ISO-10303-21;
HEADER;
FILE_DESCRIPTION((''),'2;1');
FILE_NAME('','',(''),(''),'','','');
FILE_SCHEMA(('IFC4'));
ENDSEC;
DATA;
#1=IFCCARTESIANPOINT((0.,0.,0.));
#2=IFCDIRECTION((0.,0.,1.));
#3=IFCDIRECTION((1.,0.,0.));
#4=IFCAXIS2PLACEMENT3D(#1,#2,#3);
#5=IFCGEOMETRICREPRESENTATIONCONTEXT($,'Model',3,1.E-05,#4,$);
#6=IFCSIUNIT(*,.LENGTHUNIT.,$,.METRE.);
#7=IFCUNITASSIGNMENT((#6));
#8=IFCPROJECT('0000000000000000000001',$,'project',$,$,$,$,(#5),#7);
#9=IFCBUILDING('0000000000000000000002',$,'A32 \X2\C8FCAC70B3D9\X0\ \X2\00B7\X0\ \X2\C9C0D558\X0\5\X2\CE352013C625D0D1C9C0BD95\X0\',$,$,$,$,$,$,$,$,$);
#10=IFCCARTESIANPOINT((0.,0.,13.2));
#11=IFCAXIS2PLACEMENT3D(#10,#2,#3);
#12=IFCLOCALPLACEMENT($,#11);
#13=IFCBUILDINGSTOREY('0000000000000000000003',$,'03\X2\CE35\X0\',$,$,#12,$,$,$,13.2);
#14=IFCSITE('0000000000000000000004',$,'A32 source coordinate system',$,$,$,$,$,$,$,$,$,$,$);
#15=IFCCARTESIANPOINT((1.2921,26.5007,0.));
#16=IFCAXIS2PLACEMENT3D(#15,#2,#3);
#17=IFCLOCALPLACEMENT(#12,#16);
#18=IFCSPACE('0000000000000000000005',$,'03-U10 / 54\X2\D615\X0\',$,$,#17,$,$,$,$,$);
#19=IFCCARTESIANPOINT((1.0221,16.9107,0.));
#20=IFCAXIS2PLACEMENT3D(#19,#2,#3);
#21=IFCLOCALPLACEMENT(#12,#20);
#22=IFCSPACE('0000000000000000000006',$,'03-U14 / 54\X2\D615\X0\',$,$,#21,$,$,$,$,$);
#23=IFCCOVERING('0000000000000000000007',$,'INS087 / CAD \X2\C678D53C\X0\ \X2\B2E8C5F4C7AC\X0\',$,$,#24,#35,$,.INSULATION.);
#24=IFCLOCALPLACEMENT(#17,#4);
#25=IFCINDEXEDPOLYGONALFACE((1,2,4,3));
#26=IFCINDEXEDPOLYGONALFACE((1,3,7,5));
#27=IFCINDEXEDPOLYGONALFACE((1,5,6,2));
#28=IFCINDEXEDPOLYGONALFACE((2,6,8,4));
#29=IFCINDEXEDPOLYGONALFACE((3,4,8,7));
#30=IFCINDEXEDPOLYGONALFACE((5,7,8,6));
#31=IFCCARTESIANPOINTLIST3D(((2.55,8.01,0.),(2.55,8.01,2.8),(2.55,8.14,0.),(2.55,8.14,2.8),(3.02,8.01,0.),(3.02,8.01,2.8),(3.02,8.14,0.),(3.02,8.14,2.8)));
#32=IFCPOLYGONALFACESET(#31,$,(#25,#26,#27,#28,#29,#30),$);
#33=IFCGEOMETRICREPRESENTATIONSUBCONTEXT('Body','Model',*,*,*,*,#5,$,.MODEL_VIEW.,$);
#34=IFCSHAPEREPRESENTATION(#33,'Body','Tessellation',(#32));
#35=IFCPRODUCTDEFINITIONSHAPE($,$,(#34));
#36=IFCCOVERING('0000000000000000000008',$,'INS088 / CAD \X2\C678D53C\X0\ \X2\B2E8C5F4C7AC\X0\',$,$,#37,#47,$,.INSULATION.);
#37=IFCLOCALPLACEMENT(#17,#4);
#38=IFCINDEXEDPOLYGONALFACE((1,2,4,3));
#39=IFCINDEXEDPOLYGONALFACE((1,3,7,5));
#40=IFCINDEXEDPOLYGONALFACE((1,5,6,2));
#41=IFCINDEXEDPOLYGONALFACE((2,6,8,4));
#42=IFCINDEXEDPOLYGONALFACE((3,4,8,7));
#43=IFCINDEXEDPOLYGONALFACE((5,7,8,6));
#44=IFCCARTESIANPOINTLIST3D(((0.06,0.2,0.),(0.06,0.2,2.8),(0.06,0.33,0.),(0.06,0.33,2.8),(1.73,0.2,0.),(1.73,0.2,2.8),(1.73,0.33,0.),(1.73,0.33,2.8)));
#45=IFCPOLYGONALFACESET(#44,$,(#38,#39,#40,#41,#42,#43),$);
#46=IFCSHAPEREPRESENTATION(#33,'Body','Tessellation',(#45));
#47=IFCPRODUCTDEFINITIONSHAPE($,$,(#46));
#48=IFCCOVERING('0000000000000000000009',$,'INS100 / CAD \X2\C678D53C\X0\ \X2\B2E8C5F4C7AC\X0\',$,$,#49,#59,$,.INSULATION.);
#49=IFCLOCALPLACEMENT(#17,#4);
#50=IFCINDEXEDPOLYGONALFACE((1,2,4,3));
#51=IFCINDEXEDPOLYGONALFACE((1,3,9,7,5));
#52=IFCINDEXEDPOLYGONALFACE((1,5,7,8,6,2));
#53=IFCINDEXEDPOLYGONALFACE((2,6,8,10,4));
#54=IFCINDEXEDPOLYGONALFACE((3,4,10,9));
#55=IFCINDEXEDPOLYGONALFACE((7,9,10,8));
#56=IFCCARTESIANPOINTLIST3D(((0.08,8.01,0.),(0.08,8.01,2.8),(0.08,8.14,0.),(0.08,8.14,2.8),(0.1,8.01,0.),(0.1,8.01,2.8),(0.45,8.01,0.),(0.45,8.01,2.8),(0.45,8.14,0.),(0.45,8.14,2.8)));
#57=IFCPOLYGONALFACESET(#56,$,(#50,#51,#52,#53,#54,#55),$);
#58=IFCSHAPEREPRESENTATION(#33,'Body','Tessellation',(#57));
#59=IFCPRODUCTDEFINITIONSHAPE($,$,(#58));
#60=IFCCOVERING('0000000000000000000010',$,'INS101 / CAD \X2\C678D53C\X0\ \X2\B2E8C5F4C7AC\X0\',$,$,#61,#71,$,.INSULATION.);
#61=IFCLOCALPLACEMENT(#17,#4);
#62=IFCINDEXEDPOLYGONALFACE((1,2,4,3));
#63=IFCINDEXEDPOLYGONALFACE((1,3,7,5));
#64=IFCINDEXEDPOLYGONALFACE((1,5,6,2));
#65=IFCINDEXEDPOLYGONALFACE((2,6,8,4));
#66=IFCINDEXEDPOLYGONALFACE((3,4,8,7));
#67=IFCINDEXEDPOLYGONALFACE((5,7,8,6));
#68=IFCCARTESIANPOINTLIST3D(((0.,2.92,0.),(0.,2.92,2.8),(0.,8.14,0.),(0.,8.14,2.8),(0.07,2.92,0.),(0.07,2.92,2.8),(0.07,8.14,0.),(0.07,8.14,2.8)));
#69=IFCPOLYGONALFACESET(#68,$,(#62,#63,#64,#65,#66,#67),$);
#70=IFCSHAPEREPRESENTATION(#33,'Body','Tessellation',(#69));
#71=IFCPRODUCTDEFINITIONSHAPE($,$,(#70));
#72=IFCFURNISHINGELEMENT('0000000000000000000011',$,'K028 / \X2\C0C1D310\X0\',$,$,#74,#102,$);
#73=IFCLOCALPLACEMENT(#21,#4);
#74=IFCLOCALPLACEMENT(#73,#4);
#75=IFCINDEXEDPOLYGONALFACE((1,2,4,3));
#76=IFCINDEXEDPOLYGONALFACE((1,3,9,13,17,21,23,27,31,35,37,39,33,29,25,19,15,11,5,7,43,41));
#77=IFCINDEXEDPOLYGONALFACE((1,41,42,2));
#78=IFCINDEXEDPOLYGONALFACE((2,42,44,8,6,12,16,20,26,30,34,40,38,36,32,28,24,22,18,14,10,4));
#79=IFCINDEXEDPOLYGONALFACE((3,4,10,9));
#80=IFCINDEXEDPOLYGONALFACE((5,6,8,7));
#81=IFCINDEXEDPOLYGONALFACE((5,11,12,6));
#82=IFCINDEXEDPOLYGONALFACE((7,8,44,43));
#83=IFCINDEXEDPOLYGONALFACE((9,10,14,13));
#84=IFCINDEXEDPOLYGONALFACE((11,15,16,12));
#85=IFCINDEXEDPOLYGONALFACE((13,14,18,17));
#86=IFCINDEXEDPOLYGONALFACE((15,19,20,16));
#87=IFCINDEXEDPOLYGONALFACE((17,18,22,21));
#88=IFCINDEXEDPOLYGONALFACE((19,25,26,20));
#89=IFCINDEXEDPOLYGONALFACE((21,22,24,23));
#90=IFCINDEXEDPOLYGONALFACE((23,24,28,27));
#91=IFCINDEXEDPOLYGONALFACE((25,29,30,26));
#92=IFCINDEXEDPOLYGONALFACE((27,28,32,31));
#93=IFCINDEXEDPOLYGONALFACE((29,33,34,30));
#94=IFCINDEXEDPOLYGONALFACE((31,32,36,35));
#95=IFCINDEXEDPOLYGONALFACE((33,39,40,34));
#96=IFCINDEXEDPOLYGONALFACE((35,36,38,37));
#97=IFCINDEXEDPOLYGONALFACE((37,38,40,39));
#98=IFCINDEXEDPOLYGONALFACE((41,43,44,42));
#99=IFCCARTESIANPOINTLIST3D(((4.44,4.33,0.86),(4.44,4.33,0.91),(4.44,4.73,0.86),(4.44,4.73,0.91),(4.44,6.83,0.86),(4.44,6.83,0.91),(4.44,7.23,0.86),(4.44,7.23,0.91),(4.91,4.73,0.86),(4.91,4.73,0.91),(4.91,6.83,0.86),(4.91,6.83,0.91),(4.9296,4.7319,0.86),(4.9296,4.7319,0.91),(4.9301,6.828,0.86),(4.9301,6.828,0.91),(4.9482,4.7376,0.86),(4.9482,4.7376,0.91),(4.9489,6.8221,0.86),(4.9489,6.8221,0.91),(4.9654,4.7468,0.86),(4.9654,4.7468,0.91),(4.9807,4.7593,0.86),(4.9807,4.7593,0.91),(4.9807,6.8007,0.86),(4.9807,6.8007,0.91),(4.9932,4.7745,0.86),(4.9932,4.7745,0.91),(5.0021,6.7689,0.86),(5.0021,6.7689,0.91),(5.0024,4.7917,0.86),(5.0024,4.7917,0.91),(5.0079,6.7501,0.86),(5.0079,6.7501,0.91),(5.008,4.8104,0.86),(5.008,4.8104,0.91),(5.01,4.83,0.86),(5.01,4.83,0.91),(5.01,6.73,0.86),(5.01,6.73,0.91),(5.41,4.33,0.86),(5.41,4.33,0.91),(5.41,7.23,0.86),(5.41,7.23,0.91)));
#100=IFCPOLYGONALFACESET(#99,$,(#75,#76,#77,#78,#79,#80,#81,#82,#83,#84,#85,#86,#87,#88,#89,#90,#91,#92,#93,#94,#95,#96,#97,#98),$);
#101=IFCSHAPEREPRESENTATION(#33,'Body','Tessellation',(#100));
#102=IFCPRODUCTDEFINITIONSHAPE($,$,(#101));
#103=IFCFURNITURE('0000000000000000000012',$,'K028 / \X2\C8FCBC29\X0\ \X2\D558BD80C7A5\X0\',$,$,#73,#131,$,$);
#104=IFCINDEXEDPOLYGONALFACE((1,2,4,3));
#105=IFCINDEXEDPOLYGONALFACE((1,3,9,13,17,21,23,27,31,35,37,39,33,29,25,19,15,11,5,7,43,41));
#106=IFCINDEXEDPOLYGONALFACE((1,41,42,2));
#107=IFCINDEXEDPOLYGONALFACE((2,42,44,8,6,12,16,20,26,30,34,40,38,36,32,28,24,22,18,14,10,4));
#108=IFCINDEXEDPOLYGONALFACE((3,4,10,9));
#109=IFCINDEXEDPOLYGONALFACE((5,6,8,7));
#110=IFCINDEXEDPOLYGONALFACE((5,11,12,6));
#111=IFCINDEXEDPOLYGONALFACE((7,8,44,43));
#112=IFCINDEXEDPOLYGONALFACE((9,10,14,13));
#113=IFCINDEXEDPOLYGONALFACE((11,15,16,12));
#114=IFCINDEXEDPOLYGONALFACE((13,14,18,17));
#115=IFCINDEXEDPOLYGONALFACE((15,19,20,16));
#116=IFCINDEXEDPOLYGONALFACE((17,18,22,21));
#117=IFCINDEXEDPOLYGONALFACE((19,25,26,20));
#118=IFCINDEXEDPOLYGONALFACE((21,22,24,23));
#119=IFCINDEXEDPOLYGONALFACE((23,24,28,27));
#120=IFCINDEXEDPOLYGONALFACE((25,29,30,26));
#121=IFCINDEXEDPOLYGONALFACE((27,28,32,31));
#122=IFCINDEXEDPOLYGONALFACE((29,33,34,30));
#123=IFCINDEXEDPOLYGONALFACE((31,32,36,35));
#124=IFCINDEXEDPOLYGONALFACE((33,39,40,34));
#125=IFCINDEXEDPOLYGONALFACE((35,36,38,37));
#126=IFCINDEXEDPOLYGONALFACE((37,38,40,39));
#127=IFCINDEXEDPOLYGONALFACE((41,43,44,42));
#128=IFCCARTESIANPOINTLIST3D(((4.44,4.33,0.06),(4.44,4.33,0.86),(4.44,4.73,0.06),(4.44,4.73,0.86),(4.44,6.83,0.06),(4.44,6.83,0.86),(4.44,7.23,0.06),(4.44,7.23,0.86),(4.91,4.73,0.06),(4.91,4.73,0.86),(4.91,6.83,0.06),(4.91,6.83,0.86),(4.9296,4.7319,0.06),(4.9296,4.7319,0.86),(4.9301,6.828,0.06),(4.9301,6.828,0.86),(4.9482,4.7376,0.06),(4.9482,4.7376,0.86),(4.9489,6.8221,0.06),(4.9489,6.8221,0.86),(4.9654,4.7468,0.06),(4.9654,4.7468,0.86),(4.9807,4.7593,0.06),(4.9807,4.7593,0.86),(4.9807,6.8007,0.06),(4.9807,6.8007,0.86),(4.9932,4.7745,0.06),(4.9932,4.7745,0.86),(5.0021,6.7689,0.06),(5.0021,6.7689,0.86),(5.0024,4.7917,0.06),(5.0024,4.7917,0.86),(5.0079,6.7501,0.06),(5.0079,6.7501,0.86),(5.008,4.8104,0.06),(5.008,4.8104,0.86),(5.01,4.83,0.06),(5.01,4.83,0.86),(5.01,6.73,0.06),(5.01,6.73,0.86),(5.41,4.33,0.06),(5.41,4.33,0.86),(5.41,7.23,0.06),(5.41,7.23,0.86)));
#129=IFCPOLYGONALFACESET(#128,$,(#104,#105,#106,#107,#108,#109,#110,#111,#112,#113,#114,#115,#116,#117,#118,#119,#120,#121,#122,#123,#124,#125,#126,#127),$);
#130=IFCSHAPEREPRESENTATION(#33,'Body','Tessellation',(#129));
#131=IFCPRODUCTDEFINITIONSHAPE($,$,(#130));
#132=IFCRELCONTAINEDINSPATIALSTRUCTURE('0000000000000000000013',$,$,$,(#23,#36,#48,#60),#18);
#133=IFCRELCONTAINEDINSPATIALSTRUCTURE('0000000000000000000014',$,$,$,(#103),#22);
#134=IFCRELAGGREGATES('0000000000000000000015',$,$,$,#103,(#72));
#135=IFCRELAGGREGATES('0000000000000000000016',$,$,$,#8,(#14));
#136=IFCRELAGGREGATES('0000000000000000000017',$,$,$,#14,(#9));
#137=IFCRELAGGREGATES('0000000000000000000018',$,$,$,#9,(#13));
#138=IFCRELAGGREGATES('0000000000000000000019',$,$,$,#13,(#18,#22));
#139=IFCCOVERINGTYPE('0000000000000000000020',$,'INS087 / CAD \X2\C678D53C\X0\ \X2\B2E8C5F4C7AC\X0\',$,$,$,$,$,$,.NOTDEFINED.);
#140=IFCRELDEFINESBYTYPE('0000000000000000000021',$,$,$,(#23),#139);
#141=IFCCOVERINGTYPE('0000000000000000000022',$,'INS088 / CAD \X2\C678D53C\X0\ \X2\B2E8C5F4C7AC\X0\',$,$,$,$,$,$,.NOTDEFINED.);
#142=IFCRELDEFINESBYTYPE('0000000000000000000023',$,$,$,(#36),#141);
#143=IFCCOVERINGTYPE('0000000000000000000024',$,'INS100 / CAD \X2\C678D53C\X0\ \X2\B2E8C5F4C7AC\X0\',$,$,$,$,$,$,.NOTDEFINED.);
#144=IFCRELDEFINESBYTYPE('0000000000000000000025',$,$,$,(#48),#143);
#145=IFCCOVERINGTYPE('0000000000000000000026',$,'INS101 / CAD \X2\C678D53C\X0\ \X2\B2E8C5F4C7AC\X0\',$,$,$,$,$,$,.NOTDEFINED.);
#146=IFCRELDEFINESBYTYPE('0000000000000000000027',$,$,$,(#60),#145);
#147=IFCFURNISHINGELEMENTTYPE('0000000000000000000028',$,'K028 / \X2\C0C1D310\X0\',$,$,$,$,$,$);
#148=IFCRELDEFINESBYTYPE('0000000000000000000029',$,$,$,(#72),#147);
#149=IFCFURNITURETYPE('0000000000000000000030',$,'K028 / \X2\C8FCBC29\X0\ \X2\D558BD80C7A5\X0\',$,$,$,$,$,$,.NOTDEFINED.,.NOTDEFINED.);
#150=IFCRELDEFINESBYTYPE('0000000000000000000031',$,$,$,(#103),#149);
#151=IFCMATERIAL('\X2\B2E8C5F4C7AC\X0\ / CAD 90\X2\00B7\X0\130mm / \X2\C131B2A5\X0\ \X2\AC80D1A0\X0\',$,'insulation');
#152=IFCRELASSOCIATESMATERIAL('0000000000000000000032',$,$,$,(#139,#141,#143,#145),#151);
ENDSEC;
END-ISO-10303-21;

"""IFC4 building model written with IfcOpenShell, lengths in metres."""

from ifc_helpers import new_model, si_unit, frame, origin, origin_with_axes, place, context, subcontext, project, spatial, polyline, outline, extrude, source, transform, mapped, material, type_object, type_shapes, element, aggregate, save


model = new_model("IFC4")

# Units and contexts
model_context = context("Model", 3, precision=1e-05, world=origin_with_axes())
body_context = subcontext(model_context, "Body", "Model", "MODEL_VIEW")
ifc_project = project(units=[si_unit("LENGTHUNIT", "METRE")], contexts=[model_context])

# Site, building, storey, space
storey_placement = place(None, frame((0.0, 0.0, 13.2), z_axis=(0.0, 0.0, 1.0), x_axis=(1.0, 0.0, 0.0)))
space_1_placement = place(storey_placement, frame((1.2921, 26.5007, 0.0), z_axis=(0.0, 0.0, 1.0), x_axis=(1.0, 0.0, 0.0)))
site = spatial("IfcSite", under=ifc_project, Name="A32 source coordinate system")
building = spatial("IfcBuilding", under=site, Name="A32 주거동 · 지하5층–옥탑지붕")
storey = spatial("IfcBuildingStorey", under=building, at=storey_placement, Name="03층", Elevation=13.2)
space_1 = spatial("IfcSpace", under=storey, at=space_1_placement, Name="03-U10 / 54형")

# Shared definitions
space_2_placement = place(storey_placement, frame((1.0221, 16.9107, 0.0), z_axis=(0.0, 0.0, 1.0), x_axis=(1.0, 0.0, 0.0)))
space_2 = spatial("IfcSpace", under=storey, at=space_2_placement, Name="03-U14 / 54형")

# Coverings
ifc_material = material(Name="단열재 / CAD 90·130mm / 성능 검토", Category="insulation")
covering_type_1 = type_object("IfcCoveringType", Name="INS087 / CAD 외피 단열재", PredefinedType="NOTDEFINED", material=ifc_material)
shared_shape_1 = source(origin(), body_context, "Body", "SweptSolid", [
    extrude(outline(polyline([(2.55, 8.14), (3.02, 8.14), (3.02, 8.01), (2.55, 8.01), (2.55, 8.14)])), origin(), (0.0, 0.0, 1.0), 2.8),
])
type_shapes(covering_type_1, [shared_shape_1])
covering_1_placement = place(space_1_placement, origin_with_axes())
element("IfcCovering", 1, at=covering_1_placement, inside=space_1, type_object=covering_type_1, Name="INS087 / CAD 외피 단열재", PredefinedType="INSULATION", context=body_context, shape_type="MappedRepresentation", body=[
    mapped(shared_shape_1, transform((0.0, 0.0, 0.0), scale=1.0)),
])
covering_type_2 = type_object("IfcCoveringType", Name="INS088 / CAD 외피 단열재", PredefinedType="NOTDEFINED", material=ifc_material)
shared_shape_2 = source(origin(), body_context, "Body", "SweptSolid", [
    extrude(outline(polyline([(0.06, 0.33), (1.73, 0.33), (1.73, 0.2), (0.06, 0.2), (0.06, 0.33)])), origin(), (0.0, 0.0, 1.0), 2.8),
])
type_shapes(covering_type_2, [shared_shape_2])
covering_2_placement = place(space_1_placement, origin_with_axes())
element("IfcCovering", 2, at=covering_2_placement, inside=space_1, type_object=covering_type_2, Name="INS088 / CAD 외피 단열재", PredefinedType="INSULATION", context=body_context, shape_type="MappedRepresentation", body=[
    mapped(shared_shape_2, transform((0.0, 0.0, 0.0), scale=1.0)),
])
covering_type_3 = type_object("IfcCoveringType", Name="INS100 / CAD 외피 단열재", PredefinedType="NOTDEFINED", material=ifc_material)
shared_shape_3 = source(origin(), body_context, "Body", "SweptSolid", [
    extrude(outline(polyline([(0.08, 8.01), (0.08, 8.14), (0.45, 8.14), (0.45, 8.01), (0.1, 8.01), (0.08, 8.01)])), origin(), (0.0, 0.0, 1.0), 2.8),
])
type_shapes(covering_type_3, [shared_shape_3])
covering_3_placement = place(space_1_placement, origin_with_axes())
element("IfcCovering", 3, at=covering_3_placement, inside=space_1, type_object=covering_type_3, Name="INS100 / CAD 외피 단열재", PredefinedType="INSULATION", context=body_context, shape_type="MappedRepresentation", body=[
    mapped(shared_shape_3, transform((0.0, 0.0, 0.0), scale=1.0)),
])
covering_type_4 = type_object("IfcCoveringType", Name="INS101 / CAD 외피 단열재", PredefinedType="NOTDEFINED", material=ifc_material)
shared_shape_4 = source(origin(), body_context, "Body", "SweptSolid", [
    extrude(outline(polyline([(0.0, 2.92), (0.0, 8.14), (0.07, 8.14), (0.07, 2.92), (0.0, 2.92)])), origin(), (0.0, 0.0, 1.0), 2.8),
])
type_shapes(covering_type_4, [shared_shape_4])
covering_4_placement = place(space_1_placement, origin_with_axes())
element("IfcCovering", 4, at=covering_4_placement, inside=space_1, type_object=covering_type_4, Name="INS101 / CAD 외피 단열재", PredefinedType="INSULATION", context=body_context, shape_type="MappedRepresentation", body=[
    mapped(shared_shape_4, transform((0.0, 0.0, 0.0), scale=1.0)),
])

# Furnishing element
furnishing_element_type_1 = type_object("IfcFurnishingElementType", Name="K028 / 상판")
shared_shape_5 = source(origin(), body_context, "Body", "SweptSolid", [
    extrude(outline(polyline([(5.41, 4.33), (4.44, 4.33), (4.44, 4.73), (4.91, 4.73), (4.9296, 4.7319), (4.9482, 4.7376), (4.9654, 4.7468), (4.9807, 4.7593), (4.9932, 4.7745), (5.0024, 4.7917), (5.008, 4.8104), (5.01, 4.83), (5.01, 6.73), (5.0079, 6.7501), (5.0021, 6.7689), (4.9807, 6.8007), (4.9489, 6.8221), (4.9301, 6.828), (4.91, 6.83), (4.44, 6.83), (4.44, 7.23), (5.41, 7.23), (5.41, 4.33)])), frame((0.0, 0.0, 0.86)), (0.0, 0.0, 1.0), 0.05),
])
type_shapes(furnishing_element_type_1, [shared_shape_5])
furniture_1_placement = place(space_2_placement, origin_with_axes())
furnishing_1_placement = place(furniture_1_placement, origin_with_axes())
furnishing_1 = element("IfcFurnishingElement", 5, at=furnishing_1_placement, type_object=furnishing_element_type_1, Name="K028 / 상판", context=body_context, shape_type="MappedRepresentation", body=[
    mapped(shared_shape_5, transform((0.0, 0.0, 0.0), scale=1.0)),
])

# Furniture
furniture_type_1 = type_object("IfcFurnitureType", Name="K028 / 주방 하부장", AssemblyPlace="NOTDEFINED", PredefinedType="NOTDEFINED")
shared_shape_6 = source(origin(), body_context, "Body", "SweptSolid", [
    extrude(outline(polyline([(5.41, 7.23), (5.41, 4.33), (4.44, 4.33), (4.44, 4.73), (4.91, 4.73), (4.9296, 4.7319), (4.9482, 4.7376), (4.9654, 4.7468), (4.9807, 4.7593), (4.9932, 4.7745), (5.0024, 4.7917), (5.008, 4.8104), (5.01, 4.83), (5.01, 6.73), (5.0079, 6.7501), (5.0021, 6.7689), (4.9807, 6.8007), (4.9489, 6.8221), (4.9301, 6.828), (4.91, 6.83), (4.44, 6.83), (4.44, 7.23), (5.41, 7.23)])), frame((0.0, 0.0, 0.06)), (0.0, 0.0, 1.0), 0.8),
])
type_shapes(furniture_type_1, [shared_shape_6])
furniture_1 = element("IfcFurniture", 6, at=furniture_1_placement, inside=space_2, type_object=furniture_type_1, Name="K028 / 주방 하부장", context=body_context, shape_type="MappedRepresentation", body=[
    mapped(shared_shape_6, transform((0.0, 0.0, 0.0), scale=1.0)),
])
aggregate(furniture_1, [furnishing_1])

save(model, "model.ifc")
